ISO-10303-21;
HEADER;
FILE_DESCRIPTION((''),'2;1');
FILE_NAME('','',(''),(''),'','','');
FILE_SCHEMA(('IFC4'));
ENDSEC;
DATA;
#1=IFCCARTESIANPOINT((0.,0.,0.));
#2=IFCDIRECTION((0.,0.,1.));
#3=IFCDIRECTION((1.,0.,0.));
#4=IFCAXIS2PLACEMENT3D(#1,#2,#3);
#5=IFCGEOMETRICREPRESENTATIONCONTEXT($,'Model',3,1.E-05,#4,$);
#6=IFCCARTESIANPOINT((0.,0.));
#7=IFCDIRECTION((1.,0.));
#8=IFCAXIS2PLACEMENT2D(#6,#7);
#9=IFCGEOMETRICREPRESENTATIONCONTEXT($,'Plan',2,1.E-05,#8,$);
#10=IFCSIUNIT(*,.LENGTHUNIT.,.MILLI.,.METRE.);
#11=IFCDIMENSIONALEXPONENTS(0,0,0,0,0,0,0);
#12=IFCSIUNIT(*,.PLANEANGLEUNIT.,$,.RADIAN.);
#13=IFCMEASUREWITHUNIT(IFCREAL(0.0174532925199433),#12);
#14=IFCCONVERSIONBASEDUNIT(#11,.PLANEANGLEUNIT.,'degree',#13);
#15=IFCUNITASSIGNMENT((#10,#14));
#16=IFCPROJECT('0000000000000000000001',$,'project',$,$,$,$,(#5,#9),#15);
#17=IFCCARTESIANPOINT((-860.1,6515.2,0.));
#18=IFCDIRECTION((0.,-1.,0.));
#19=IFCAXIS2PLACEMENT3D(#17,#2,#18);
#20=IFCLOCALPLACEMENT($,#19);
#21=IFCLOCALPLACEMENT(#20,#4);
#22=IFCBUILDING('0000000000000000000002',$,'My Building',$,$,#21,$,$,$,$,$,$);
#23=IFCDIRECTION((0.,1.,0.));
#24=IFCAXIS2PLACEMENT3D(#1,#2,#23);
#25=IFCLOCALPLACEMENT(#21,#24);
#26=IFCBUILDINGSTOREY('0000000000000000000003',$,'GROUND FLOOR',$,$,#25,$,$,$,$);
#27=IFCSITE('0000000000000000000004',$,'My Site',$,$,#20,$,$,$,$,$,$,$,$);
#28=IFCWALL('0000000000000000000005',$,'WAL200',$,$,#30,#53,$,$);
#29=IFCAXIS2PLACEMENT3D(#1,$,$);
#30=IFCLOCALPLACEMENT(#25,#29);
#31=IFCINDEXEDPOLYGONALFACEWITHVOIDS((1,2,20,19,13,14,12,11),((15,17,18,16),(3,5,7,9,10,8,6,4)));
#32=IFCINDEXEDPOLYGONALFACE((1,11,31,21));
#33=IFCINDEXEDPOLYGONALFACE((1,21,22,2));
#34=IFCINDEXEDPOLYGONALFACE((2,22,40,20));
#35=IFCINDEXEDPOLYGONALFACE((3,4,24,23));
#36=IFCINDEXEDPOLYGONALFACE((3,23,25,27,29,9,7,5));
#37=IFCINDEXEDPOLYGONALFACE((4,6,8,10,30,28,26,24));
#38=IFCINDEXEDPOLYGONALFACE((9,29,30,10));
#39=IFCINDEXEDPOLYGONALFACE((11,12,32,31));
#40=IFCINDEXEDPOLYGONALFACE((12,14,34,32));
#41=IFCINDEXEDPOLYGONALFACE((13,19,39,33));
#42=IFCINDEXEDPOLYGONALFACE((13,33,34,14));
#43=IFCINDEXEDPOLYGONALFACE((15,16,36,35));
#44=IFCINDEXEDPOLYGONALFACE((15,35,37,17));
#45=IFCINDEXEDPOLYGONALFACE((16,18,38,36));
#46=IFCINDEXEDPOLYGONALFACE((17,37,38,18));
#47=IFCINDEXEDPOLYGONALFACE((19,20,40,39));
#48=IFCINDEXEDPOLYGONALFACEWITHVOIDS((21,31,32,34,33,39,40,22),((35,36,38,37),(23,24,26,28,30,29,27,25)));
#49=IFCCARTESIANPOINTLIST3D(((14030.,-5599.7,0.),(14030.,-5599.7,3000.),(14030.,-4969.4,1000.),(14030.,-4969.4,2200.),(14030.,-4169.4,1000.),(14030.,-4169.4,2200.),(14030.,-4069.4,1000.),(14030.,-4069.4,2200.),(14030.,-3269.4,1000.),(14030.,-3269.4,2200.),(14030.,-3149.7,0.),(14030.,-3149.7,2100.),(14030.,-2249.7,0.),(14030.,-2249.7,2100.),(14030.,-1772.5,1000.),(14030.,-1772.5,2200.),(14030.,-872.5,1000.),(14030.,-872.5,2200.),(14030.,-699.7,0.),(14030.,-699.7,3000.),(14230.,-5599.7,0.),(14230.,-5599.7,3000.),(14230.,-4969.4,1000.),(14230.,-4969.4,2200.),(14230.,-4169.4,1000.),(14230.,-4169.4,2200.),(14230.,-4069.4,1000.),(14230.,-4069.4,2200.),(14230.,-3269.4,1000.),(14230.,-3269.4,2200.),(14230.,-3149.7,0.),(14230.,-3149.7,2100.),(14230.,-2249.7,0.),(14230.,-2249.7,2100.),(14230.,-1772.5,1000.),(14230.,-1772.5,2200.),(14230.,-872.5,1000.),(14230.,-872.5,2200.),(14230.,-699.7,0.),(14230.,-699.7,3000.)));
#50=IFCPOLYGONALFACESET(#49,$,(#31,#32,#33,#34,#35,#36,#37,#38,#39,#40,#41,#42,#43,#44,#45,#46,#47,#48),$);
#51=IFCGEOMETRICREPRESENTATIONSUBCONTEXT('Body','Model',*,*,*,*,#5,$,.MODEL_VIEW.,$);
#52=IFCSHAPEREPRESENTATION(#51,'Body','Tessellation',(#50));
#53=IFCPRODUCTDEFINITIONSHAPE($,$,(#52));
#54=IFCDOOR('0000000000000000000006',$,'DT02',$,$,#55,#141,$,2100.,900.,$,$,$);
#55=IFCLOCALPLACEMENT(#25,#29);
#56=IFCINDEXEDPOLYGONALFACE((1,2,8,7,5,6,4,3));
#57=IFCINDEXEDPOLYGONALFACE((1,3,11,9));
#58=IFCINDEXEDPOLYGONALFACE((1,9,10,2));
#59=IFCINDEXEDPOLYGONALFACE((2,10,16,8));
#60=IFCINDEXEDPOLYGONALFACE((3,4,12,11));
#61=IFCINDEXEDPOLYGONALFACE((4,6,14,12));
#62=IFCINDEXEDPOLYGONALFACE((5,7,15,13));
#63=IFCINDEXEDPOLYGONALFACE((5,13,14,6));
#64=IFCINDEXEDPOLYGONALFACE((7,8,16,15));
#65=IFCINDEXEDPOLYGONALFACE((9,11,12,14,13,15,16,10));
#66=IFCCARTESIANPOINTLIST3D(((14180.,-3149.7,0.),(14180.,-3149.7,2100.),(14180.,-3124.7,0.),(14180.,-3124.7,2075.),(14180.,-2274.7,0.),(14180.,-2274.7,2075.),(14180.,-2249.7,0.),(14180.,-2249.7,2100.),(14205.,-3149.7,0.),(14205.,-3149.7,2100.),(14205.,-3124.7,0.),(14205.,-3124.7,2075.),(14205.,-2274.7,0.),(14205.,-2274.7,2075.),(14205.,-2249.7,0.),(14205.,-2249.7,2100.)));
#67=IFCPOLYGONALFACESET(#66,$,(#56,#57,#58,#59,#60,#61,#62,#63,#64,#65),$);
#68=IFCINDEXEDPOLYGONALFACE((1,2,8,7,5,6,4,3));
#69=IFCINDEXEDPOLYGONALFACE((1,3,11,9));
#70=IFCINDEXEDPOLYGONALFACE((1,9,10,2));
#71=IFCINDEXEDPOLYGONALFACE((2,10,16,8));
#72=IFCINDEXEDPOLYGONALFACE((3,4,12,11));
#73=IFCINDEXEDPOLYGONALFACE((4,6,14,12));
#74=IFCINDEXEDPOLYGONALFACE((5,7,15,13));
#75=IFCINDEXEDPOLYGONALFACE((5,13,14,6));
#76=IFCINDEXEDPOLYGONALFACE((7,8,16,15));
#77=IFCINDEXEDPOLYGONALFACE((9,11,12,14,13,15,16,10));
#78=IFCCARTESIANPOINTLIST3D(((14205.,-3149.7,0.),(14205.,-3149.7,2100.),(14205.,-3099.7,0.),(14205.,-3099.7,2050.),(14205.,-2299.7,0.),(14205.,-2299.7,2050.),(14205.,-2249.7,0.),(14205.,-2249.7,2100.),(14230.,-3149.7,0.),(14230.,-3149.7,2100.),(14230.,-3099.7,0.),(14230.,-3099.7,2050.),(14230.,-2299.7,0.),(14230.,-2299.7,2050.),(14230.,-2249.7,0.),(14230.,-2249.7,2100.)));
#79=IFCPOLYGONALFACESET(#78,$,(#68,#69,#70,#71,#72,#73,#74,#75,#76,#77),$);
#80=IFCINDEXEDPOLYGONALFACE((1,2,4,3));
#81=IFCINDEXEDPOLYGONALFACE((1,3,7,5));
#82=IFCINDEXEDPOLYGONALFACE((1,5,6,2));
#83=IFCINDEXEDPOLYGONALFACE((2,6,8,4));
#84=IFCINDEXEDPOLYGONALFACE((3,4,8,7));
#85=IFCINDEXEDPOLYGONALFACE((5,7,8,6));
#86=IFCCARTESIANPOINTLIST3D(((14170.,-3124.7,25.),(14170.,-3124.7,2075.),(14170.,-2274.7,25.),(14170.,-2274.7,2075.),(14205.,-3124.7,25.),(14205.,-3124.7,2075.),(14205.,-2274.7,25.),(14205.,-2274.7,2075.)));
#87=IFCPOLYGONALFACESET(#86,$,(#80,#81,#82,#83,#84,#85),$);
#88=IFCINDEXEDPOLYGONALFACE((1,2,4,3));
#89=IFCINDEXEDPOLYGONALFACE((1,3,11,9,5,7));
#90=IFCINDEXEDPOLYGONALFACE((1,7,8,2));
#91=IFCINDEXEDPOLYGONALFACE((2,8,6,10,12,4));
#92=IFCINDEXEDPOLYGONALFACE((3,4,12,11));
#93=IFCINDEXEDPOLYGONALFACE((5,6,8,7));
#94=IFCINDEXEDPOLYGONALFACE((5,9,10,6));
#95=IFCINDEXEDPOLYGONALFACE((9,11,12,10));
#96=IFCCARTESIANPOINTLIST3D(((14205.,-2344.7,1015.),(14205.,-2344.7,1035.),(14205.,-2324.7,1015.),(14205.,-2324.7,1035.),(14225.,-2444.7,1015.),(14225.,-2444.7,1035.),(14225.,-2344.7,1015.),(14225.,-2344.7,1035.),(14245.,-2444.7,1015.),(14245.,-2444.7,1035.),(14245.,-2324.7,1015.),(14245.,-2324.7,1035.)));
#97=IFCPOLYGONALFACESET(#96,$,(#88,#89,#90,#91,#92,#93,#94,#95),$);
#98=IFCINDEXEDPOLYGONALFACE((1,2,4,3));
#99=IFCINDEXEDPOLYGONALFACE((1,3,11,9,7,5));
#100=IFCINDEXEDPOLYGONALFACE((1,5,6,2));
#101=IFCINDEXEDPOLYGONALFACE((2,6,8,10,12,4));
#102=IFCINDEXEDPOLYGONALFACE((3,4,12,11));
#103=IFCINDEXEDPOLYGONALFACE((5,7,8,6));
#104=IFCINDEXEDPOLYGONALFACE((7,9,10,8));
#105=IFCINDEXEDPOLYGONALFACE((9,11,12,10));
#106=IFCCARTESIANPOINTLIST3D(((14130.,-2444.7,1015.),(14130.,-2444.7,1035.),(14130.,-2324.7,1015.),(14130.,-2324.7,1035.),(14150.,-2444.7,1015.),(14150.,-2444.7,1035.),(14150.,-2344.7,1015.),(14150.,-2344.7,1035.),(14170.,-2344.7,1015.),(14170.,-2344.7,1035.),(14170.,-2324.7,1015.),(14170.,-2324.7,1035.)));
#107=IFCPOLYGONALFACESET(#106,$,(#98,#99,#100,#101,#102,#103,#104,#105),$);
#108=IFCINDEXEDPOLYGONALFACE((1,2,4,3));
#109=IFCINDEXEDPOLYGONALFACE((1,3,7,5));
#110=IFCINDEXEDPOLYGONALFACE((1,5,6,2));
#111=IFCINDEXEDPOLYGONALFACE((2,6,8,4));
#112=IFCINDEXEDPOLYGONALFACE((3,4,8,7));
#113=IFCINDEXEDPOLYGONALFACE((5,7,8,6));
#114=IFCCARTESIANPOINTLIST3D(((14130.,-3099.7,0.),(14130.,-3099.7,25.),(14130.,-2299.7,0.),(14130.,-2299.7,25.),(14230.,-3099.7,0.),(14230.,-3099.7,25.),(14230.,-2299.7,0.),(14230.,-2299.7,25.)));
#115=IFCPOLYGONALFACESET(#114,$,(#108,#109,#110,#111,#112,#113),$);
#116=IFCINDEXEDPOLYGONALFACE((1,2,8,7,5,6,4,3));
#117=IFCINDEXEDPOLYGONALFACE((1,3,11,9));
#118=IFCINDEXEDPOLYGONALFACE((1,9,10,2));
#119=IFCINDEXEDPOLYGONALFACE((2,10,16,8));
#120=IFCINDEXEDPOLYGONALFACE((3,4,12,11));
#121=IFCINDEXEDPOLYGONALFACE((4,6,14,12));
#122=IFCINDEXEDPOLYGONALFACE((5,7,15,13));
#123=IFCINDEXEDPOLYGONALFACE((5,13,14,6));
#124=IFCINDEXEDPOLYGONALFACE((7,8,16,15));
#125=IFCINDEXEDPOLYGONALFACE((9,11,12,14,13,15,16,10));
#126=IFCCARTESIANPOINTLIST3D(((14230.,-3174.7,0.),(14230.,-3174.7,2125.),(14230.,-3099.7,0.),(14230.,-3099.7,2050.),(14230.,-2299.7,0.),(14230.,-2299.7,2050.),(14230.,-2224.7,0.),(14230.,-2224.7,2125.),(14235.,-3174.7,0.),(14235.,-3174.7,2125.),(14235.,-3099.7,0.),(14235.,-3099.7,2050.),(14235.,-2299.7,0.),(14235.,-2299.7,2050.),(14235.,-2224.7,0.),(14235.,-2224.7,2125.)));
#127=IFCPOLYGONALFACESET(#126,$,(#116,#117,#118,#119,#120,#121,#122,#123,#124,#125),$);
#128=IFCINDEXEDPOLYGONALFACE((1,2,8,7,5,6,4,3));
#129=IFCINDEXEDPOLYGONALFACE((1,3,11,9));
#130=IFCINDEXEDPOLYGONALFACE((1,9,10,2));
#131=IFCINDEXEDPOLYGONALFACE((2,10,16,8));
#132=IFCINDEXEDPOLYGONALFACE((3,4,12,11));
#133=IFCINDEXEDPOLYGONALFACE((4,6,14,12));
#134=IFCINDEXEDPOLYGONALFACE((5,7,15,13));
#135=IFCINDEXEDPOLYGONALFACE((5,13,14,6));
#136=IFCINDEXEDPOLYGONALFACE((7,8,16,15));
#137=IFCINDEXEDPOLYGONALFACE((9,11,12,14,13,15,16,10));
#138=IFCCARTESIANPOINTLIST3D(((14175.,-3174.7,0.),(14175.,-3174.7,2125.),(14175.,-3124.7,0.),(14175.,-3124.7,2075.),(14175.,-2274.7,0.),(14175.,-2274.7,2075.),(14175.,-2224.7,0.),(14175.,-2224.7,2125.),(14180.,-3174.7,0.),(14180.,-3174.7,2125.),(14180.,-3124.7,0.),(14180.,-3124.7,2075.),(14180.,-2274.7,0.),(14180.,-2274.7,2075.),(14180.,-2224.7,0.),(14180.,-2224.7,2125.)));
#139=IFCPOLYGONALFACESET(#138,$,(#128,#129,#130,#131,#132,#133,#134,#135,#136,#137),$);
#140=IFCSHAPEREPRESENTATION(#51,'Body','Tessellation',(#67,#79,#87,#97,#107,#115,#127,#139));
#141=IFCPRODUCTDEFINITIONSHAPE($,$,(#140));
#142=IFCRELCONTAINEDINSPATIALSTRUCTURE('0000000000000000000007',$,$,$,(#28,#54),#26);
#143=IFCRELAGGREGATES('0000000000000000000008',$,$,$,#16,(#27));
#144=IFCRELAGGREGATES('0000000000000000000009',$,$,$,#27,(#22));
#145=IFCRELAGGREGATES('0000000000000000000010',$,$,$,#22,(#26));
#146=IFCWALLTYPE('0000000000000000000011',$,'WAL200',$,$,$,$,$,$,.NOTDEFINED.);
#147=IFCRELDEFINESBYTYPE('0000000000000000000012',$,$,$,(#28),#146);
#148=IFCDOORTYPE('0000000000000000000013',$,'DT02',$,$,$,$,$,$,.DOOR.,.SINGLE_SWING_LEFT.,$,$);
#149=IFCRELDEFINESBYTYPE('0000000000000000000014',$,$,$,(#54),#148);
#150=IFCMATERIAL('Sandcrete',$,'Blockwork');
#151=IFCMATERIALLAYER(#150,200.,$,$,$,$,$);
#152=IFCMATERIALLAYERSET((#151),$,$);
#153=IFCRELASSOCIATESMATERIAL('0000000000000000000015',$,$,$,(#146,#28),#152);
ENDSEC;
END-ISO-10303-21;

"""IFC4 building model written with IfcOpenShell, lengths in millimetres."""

from ifc_helpers import new_model, entity, si_unit, converted_unit, frame, origin_with_axes, origin_2d_with_axis, place, context, subcontext, project, spatial, line, indexed_curve, outline, extrude, shape, source, transform, mapped, material, layer, layer_set, layer_usage, type_object, type_shapes, element, fill, save


model = new_model("IFC4")

# Units and contexts
model_context = context("Model", 3, precision=1e-05, world=origin_with_axes())
plan_context = context("Plan", 2, precision=1e-05, world=origin_2d_with_axis())
body_context_1 = subcontext(model_context, "Body", "Model", "MODEL_VIEW")
body_context_2 = subcontext(plan_context, "Body", "Plan", "PLAN_VIEW")
ifc_project = project(units=[si_unit("LENGTHUNIT", "METRE", prefix="MILLI"), converted_unit("PLANEANGLEUNIT", "degree", entity("IfcReal", 0.0174532925199433), si_unit("PLANEANGLEUNIT", "RADIAN"), dimensions=[0, 0, 0, 0, 0, 0, 0])], contexts=[model_context, plan_context])

# Site, building, storey
site_placement = place(None, frame((-860.1, 6515.2, 0.0), z_axis=(0.0, 0.0, 1.0), x_axis=(0.0, -1.0, 0.0)))
site = spatial("IfcSite", under=ifc_project, at=site_placement, Name="My Site")
building_placement = place(site_placement, frame((0.0, 0.0, 0.0), z_axis=(0.0, 0.0, 1.0), x_axis=(1.0, 0.0, 0.0)))
building = spatial("IfcBuilding", under=site, at=building_placement, Name="My Building")
storey_placement = place(building_placement, frame((0.0, 0.0, 0.0), z_axis=(0.0, 0.0, 1.0), x_axis=(0.0, 1.0, 0.0)))
storey = spatial("IfcBuildingStorey", under=building, at=storey_placement, Name="GROUND FLOOR")

# Shared definitions
ifc_material = material(Name="Sandcrete", Category="Blockwork")

# Shared definitions
ifc_layer_1 = layer(ifc_material, 200.0)
ifc_layer_set_1 = layer_set([ifc_layer_1])
wall_type_1 = type_object("IfcWallType", Name="WAL200", PredefinedType="NOTDEFINED", material=ifc_layer_set_1)

# Wall, openings, door
ifc_layer_usage_1 = layer_usage(ifc_layer_set_1, "AXIS2", "POSITIVE", 0.0)
wall_1_placement = place(storey_placement, frame((14230.0, -5599.7, 0.0), z_axis=(0.0, 0.0, 1.0), x_axis=(0.0, 1.0, 0.0)))
wall_1 = element("IfcWall", 1, at=wall_1_placement, inside=storey, type_object=wall_type_1, material=ifc_layer_usage_1, Name="WAL200", context=body_context_1, shape_type="SweptSolid", body=[
    extrude(outline(indexed_curve([(0.0, 0.0), (0.0, 200.0), (4900.0, 200.0), (4900.0, 0.0), (0.0, 0.0)], self_intersect=False)), origin_with_axes(), (0.0, 0.0, 1.0), 3000.0),
])
shared_shape_1 = source(origin_with_axes(), body_context_1, "Body", "SweptSolid", [
    extrude(outline(indexed_curve([(0.0, 0.0), (900.0, 0.0), (900.0, 2100.0), (0.0, 2100.0)], segments=[line(1, 2), line(2, 3), line(3, 4), line(4, 1)])), frame((0.0, -100.0, 0.0), z_axis=(0.0, -1.0, 0.0), x_axis=(1.0, 0.0, 0.0)), (0.0, 0.0, -1.0), 400.0),
])
opening_1_placement = place(wall_1_placement, frame((2450.0, 0.0, 0.0), z_axis=(0.0, 0.0, 1.0), x_axis=(1.0, 0.0, 0.0)))
opening_1 = element("IfcOpeningElement", 2, at=opening_1_placement, cuts=wall_1, PredefinedType="OPENING", context=body_context_1, shape_type="MappedRepresentation", body=[
    mapped(shared_shape_1, transform((0.0, 0.0, 0.0), x_axis=(1.0, 0.0, 0.0), y_axis=(0.0, 1.0, 0.0), z_axis=(0.0, 0.0, 1.0), scale=1.0)),
])
shared_shape_2 = source(origin_with_axes(), body_context_1, "Body", "SweptSolid", [
    extrude(outline(indexed_curve([(0.0, 0.0), (900.0, 0.0), (900.0, 1200.0), (0.0, 1200.0)], segments=[line(1, 2), line(2, 3), line(3, 4), line(4, 1)])), frame((0.0, -100.0, 0.0), z_axis=(0.0, -1.0, 0.0), x_axis=(1.0, 0.0, 0.0)), (0.0, 0.0, -1.0), 400.0),
])
opening_2_placement = place(wall_1_placement, frame((3827.1, 79.5, 1000.0), z_axis=(0.0, 0.0, 1.0), x_axis=(1.0, 0.0, 0.0)))
element("IfcOpeningElement", 3, at=opening_2_placement, cuts=wall_1, PredefinedType="OPENING", context=body_context_1, shape_type="MappedRepresentation", body=[
    mapped(shared_shape_2, transform((0.0, 0.0, 0.0), x_axis=(1.0, 0.0, 0.0), y_axis=(0.0, 1.0, 0.0), z_axis=(0.0, 0.0, 1.0), scale=1.0)),
])
opening_3_placement = place(wall_1_placement, frame((630.2, 79.4, 1000.0), z_axis=(0.0, 0.0, 1.0), x_axis=(1.0, 0.0, 0.0)))
element("IfcOpeningElement", 4, at=opening_3_placement, cuts=wall_1, PredefinedType="OPENING", context=body_context_1, shape_type="MappedRepresentation", body=[
    mapped(shared_shape_2, transform((0.0, 0.0, 0.0), x_axis=(1.0, 0.0, 0.0), y_axis=(0.0, 1.0, 0.0), z_axis=(0.0, 0.0, 1.0), scale=1.0)),
])
opening_4_placement = place(wall_1_placement, frame((1430.2, 79.5, 1000.0), z_axis=(0.0, 0.0, 1.0), x_axis=(1.0, 0.0, 0.0)))
element("IfcOpeningElement", 5, at=opening_4_placement, cuts=wall_1, PredefinedType="OPENING", context=body_context_1, shape_type="MappedRepresentation", body=[
    mapped(shared_shape_2, transform((0.0, 0.0, 0.0), x_axis=(1.0, 0.0, 0.0), y_axis=(0.0, 1.0, 0.0), z_axis=(0.0, 0.0, 1.0), scale=1.0)),
])
door_type_1 = type_object("IfcDoorType", Name="DT02", OperationType="SINGLE_SWING_LEFT", PredefinedType="DOOR")
shared_shape_3 = source(origin_with_axes(), body_context_1, "Body", "SweptSolid", [
    extrude(outline(indexed_curve([(0.0, 0.0), (0.0, 2100.0), (900.0, 2100.0), (900.0, 0.0), (875.0, 0.0), (875.0, 2075.0), (25.0, 2075.0), (25.0, 0.0)], segments=[line(1, 2), line(2, 3), line(3, 4), line(4, 5), line(5, 6), line(6, 7), line(7, 8), line(8, 1)])), frame((0.0, 25.0, 0.0), z_axis=(0.0, -1.0, 0.0), x_axis=(1.0, 0.0, 0.0)), (0.0, 0.0, -1.0), 25.0),
    extrude(outline(indexed_curve([(0.0, 0.0), (0.0, 2100.0), (900.0, 2100.0), (900.0, 0.0), (850.0, 0.0), (850.0, 2050.0), (50.0, 2050.0), (50.0, 0.0)], segments=[line(1, 2), line(2, 3), line(3, 4), line(4, 5), line(5, 6), line(6, 7), line(7, 8), line(8, 1)])), frame((0.0, 0.0, 0.0), z_axis=(0.0, -1.0, 0.0), x_axis=(1.0, 0.0, 0.0)), (0.0, 0.0, -1.0), 25.0),
    extrude(outline(indexed_curve([(0.0, 0.0), (850.0, 0.0), (850.0, 35.0), (0.0, 35.0)], segments=[line(1, 2), line(2, 3), line(3, 4), line(4, 1)])), frame((25.0, 25.0, 25.0), z_axis=(0.0, 0.0, 1.0), x_axis=(1.0, 0.0, 0.0)), (0.0, 0.0, 1.0), 2050.0),
    extrude(outline(indexed_curve([(0.0, 0.0), (0.0, -40.0), (-120.0, -40.0), (-120.0, -20.0), (-20.0, -20.0), (-20.0, 0.0)], segments=[line(1, 2), line(2, 3), line(3, 4), line(4, 5), line(5, 6), line(6, 1)])), frame((825.0, 25.0, 1015.0), z_axis=(0.0, 0.0, 1.0), x_axis=(1.0, 0.0, 0.0)), (0.0, 0.0, 1.0), 20.0),
    extrude(outline(indexed_curve([(0.0, 0.0), (0.0, 40.0), (-120.0, 40.0), (-120.0, 20.0), (-20.0, 20.0), (-20.0, 0.0)], segments=[line(1, 2), line(2, 3), line(3, 4), line(4, 5), line(5, 6), line(6, 1)])), frame((825.0, 60.0, 1015.0), z_axis=(0.0, 0.0, 1.0), x_axis=(1.0, 0.0, 0.0)), (0.0, 0.0, 1.0), 20.0),
    extrude(outline(indexed_curve([(0.0, 0.0), (800.0, 0.0), (800.0, 100.0), (0.0, 100.0)], segments=[line(1, 2), line(2, 3), line(3, 4), line(4, 1)])), frame((50.0, 0.0, 0.0), z_axis=(0.0, 0.0, 1.0), x_axis=(1.0, 0.0, 0.0)), (0.0, 0.0, 1.0), 25.0),
    extrude(outline(indexed_curve([(0.0, 0.0), (0.0, 2125.0), (950.0, 2125.0), (950.0, 0.0), (875.0, 0.0), (875.0, 2050.0), (75.0, 2050.0), (75.0, 0.0)], segments=[line(1, 2), line(2, 3), line(3, 4), line(4, 5), line(5, 6), line(6, 7), line(7, 8), line(8, 1)])), frame((-25.0, -5.0, 0.0), z_axis=(0.0, -1.0, 0.0), x_axis=(1.0, 0.0, 0.0)), (0.0, 0.0, -1.0), 5.0),
    extrude(outline(indexed_curve([(0.0, 0.0), (0.0, 2125.0), (950.0, 2125.0), (950.0, 0.0), (900.0, 0.0), (900.0, 2075.0), (50.0, 2075.0), (50.0, 0.0)], segments=[line(1, 2), line(2, 3), line(3, 4), line(4, 5), line(5, 6), line(6, 7), line(7, 8), line(8, 1)])), frame((-25.0, 50.0, 0.0), z_axis=(0.0, -1.0, 0.0), x_axis=(1.0, 0.0, 0.0)), (0.0, 0.0, -1.0), 5.0),
])
shared_shape_4 = source(origin_with_axes(), body_context_2, "Body", "Curve2D", [
    entity("IfcIndexedPolyCurve", entity("IfcCartesianPointList2D", [[0.0, 0.0], [0.0, 50.0], [25.0, 50.0], [25.0, 25.0], [50.0, 25.0], [50.0, 0.0]]), [entity("IfcLineIndex", [1, 2]), entity("IfcLineIndex", [2, 3]), entity("IfcLineIndex", [3, 4]), entity("IfcLineIndex", [4, 5]), entity("IfcLineIndex", [5, 6]), entity("IfcLineIndex", [6, 1])]),
    entity("IfcIndexedPolyCurve", entity("IfcCartesianPointList2D", [[900.0, 0.0], [900.0, 50.0], [875.0, 50.0], [875.0, 25.0], [850.0, 25.0], [850.0, 0.0]]), [entity("IfcLineIndex", [1, 2]), entity("IfcLineIndex", [2, 3]), entity("IfcLineIndex", [3, 4]), entity("IfcLineIndex", [4, 5]), entity("IfcLineIndex", [5, 6]), entity("IfcLineIndex", [6, 1])]),
    entity("IfcTrimmedCurve", entity("IfcEllipse", entity("IfcAxis2Placement2D", entity("IfcCartesianPoint", [60.0, 50.0]), entity("IfcDirection", [1.0, 0.0])), 815.0, 850.0), [entity("IfcCartesianPoint", [875.0, 50.0])], [entity("IfcCartesianPoint", [60.0, 900.0])], True, "CARTESIAN"),
    entity("IfcIndexedPolyCurve", entity("IfcCartesianPointList2D", [[25.0, 50.0], [60.0, 50.0], [60.0, 900.0], [25.0, 900.0]]), [entity("IfcLineIndex", [1, 2]), entity("IfcLineIndex", [2, 3]), entity("IfcLineIndex", [3, 4]), entity("IfcLineIndex", [4, 1])]),
])
type_shapes(door_type_1, [shared_shape_3, shared_shape_4])
door_1_placement = place(opening_1_placement, frame((0.0, 0.0, 0.0), z_axis=(0.0, 0.0, 1.0), x_axis=(1.0, 0.0, 0.0)))
door_1 = element("IfcDoor", 6, at=door_1_placement, inside=storey, type_object=door_type_1, Name="DT02", OverallHeight=2100.0, OverallWidth=900.0, shapes=[
    shape(body_context_1, "Body", "MappedRepresentation", [mapped(shared_shape_3, transform((0.0, 0.0, 0.0), x_axis=(1.0, 0.0, 0.0), y_axis=(0.0, 1.0, 0.0), z_axis=(0.0, 0.0, 1.0), scale=1.0))]),
    shape(body_context_2, "Body", "MappedRepresentation", [mapped(shared_shape_4, transform((0.0, 0.0, 0.0), x_axis=(1.0, 0.0, 0.0), y_axis=(0.0, 1.0, 0.0), z_axis=(0.0, 0.0, 1.0), scale=1.0))]),
])
fill(opening_1, door_1)

save(model, "model.ifc")
